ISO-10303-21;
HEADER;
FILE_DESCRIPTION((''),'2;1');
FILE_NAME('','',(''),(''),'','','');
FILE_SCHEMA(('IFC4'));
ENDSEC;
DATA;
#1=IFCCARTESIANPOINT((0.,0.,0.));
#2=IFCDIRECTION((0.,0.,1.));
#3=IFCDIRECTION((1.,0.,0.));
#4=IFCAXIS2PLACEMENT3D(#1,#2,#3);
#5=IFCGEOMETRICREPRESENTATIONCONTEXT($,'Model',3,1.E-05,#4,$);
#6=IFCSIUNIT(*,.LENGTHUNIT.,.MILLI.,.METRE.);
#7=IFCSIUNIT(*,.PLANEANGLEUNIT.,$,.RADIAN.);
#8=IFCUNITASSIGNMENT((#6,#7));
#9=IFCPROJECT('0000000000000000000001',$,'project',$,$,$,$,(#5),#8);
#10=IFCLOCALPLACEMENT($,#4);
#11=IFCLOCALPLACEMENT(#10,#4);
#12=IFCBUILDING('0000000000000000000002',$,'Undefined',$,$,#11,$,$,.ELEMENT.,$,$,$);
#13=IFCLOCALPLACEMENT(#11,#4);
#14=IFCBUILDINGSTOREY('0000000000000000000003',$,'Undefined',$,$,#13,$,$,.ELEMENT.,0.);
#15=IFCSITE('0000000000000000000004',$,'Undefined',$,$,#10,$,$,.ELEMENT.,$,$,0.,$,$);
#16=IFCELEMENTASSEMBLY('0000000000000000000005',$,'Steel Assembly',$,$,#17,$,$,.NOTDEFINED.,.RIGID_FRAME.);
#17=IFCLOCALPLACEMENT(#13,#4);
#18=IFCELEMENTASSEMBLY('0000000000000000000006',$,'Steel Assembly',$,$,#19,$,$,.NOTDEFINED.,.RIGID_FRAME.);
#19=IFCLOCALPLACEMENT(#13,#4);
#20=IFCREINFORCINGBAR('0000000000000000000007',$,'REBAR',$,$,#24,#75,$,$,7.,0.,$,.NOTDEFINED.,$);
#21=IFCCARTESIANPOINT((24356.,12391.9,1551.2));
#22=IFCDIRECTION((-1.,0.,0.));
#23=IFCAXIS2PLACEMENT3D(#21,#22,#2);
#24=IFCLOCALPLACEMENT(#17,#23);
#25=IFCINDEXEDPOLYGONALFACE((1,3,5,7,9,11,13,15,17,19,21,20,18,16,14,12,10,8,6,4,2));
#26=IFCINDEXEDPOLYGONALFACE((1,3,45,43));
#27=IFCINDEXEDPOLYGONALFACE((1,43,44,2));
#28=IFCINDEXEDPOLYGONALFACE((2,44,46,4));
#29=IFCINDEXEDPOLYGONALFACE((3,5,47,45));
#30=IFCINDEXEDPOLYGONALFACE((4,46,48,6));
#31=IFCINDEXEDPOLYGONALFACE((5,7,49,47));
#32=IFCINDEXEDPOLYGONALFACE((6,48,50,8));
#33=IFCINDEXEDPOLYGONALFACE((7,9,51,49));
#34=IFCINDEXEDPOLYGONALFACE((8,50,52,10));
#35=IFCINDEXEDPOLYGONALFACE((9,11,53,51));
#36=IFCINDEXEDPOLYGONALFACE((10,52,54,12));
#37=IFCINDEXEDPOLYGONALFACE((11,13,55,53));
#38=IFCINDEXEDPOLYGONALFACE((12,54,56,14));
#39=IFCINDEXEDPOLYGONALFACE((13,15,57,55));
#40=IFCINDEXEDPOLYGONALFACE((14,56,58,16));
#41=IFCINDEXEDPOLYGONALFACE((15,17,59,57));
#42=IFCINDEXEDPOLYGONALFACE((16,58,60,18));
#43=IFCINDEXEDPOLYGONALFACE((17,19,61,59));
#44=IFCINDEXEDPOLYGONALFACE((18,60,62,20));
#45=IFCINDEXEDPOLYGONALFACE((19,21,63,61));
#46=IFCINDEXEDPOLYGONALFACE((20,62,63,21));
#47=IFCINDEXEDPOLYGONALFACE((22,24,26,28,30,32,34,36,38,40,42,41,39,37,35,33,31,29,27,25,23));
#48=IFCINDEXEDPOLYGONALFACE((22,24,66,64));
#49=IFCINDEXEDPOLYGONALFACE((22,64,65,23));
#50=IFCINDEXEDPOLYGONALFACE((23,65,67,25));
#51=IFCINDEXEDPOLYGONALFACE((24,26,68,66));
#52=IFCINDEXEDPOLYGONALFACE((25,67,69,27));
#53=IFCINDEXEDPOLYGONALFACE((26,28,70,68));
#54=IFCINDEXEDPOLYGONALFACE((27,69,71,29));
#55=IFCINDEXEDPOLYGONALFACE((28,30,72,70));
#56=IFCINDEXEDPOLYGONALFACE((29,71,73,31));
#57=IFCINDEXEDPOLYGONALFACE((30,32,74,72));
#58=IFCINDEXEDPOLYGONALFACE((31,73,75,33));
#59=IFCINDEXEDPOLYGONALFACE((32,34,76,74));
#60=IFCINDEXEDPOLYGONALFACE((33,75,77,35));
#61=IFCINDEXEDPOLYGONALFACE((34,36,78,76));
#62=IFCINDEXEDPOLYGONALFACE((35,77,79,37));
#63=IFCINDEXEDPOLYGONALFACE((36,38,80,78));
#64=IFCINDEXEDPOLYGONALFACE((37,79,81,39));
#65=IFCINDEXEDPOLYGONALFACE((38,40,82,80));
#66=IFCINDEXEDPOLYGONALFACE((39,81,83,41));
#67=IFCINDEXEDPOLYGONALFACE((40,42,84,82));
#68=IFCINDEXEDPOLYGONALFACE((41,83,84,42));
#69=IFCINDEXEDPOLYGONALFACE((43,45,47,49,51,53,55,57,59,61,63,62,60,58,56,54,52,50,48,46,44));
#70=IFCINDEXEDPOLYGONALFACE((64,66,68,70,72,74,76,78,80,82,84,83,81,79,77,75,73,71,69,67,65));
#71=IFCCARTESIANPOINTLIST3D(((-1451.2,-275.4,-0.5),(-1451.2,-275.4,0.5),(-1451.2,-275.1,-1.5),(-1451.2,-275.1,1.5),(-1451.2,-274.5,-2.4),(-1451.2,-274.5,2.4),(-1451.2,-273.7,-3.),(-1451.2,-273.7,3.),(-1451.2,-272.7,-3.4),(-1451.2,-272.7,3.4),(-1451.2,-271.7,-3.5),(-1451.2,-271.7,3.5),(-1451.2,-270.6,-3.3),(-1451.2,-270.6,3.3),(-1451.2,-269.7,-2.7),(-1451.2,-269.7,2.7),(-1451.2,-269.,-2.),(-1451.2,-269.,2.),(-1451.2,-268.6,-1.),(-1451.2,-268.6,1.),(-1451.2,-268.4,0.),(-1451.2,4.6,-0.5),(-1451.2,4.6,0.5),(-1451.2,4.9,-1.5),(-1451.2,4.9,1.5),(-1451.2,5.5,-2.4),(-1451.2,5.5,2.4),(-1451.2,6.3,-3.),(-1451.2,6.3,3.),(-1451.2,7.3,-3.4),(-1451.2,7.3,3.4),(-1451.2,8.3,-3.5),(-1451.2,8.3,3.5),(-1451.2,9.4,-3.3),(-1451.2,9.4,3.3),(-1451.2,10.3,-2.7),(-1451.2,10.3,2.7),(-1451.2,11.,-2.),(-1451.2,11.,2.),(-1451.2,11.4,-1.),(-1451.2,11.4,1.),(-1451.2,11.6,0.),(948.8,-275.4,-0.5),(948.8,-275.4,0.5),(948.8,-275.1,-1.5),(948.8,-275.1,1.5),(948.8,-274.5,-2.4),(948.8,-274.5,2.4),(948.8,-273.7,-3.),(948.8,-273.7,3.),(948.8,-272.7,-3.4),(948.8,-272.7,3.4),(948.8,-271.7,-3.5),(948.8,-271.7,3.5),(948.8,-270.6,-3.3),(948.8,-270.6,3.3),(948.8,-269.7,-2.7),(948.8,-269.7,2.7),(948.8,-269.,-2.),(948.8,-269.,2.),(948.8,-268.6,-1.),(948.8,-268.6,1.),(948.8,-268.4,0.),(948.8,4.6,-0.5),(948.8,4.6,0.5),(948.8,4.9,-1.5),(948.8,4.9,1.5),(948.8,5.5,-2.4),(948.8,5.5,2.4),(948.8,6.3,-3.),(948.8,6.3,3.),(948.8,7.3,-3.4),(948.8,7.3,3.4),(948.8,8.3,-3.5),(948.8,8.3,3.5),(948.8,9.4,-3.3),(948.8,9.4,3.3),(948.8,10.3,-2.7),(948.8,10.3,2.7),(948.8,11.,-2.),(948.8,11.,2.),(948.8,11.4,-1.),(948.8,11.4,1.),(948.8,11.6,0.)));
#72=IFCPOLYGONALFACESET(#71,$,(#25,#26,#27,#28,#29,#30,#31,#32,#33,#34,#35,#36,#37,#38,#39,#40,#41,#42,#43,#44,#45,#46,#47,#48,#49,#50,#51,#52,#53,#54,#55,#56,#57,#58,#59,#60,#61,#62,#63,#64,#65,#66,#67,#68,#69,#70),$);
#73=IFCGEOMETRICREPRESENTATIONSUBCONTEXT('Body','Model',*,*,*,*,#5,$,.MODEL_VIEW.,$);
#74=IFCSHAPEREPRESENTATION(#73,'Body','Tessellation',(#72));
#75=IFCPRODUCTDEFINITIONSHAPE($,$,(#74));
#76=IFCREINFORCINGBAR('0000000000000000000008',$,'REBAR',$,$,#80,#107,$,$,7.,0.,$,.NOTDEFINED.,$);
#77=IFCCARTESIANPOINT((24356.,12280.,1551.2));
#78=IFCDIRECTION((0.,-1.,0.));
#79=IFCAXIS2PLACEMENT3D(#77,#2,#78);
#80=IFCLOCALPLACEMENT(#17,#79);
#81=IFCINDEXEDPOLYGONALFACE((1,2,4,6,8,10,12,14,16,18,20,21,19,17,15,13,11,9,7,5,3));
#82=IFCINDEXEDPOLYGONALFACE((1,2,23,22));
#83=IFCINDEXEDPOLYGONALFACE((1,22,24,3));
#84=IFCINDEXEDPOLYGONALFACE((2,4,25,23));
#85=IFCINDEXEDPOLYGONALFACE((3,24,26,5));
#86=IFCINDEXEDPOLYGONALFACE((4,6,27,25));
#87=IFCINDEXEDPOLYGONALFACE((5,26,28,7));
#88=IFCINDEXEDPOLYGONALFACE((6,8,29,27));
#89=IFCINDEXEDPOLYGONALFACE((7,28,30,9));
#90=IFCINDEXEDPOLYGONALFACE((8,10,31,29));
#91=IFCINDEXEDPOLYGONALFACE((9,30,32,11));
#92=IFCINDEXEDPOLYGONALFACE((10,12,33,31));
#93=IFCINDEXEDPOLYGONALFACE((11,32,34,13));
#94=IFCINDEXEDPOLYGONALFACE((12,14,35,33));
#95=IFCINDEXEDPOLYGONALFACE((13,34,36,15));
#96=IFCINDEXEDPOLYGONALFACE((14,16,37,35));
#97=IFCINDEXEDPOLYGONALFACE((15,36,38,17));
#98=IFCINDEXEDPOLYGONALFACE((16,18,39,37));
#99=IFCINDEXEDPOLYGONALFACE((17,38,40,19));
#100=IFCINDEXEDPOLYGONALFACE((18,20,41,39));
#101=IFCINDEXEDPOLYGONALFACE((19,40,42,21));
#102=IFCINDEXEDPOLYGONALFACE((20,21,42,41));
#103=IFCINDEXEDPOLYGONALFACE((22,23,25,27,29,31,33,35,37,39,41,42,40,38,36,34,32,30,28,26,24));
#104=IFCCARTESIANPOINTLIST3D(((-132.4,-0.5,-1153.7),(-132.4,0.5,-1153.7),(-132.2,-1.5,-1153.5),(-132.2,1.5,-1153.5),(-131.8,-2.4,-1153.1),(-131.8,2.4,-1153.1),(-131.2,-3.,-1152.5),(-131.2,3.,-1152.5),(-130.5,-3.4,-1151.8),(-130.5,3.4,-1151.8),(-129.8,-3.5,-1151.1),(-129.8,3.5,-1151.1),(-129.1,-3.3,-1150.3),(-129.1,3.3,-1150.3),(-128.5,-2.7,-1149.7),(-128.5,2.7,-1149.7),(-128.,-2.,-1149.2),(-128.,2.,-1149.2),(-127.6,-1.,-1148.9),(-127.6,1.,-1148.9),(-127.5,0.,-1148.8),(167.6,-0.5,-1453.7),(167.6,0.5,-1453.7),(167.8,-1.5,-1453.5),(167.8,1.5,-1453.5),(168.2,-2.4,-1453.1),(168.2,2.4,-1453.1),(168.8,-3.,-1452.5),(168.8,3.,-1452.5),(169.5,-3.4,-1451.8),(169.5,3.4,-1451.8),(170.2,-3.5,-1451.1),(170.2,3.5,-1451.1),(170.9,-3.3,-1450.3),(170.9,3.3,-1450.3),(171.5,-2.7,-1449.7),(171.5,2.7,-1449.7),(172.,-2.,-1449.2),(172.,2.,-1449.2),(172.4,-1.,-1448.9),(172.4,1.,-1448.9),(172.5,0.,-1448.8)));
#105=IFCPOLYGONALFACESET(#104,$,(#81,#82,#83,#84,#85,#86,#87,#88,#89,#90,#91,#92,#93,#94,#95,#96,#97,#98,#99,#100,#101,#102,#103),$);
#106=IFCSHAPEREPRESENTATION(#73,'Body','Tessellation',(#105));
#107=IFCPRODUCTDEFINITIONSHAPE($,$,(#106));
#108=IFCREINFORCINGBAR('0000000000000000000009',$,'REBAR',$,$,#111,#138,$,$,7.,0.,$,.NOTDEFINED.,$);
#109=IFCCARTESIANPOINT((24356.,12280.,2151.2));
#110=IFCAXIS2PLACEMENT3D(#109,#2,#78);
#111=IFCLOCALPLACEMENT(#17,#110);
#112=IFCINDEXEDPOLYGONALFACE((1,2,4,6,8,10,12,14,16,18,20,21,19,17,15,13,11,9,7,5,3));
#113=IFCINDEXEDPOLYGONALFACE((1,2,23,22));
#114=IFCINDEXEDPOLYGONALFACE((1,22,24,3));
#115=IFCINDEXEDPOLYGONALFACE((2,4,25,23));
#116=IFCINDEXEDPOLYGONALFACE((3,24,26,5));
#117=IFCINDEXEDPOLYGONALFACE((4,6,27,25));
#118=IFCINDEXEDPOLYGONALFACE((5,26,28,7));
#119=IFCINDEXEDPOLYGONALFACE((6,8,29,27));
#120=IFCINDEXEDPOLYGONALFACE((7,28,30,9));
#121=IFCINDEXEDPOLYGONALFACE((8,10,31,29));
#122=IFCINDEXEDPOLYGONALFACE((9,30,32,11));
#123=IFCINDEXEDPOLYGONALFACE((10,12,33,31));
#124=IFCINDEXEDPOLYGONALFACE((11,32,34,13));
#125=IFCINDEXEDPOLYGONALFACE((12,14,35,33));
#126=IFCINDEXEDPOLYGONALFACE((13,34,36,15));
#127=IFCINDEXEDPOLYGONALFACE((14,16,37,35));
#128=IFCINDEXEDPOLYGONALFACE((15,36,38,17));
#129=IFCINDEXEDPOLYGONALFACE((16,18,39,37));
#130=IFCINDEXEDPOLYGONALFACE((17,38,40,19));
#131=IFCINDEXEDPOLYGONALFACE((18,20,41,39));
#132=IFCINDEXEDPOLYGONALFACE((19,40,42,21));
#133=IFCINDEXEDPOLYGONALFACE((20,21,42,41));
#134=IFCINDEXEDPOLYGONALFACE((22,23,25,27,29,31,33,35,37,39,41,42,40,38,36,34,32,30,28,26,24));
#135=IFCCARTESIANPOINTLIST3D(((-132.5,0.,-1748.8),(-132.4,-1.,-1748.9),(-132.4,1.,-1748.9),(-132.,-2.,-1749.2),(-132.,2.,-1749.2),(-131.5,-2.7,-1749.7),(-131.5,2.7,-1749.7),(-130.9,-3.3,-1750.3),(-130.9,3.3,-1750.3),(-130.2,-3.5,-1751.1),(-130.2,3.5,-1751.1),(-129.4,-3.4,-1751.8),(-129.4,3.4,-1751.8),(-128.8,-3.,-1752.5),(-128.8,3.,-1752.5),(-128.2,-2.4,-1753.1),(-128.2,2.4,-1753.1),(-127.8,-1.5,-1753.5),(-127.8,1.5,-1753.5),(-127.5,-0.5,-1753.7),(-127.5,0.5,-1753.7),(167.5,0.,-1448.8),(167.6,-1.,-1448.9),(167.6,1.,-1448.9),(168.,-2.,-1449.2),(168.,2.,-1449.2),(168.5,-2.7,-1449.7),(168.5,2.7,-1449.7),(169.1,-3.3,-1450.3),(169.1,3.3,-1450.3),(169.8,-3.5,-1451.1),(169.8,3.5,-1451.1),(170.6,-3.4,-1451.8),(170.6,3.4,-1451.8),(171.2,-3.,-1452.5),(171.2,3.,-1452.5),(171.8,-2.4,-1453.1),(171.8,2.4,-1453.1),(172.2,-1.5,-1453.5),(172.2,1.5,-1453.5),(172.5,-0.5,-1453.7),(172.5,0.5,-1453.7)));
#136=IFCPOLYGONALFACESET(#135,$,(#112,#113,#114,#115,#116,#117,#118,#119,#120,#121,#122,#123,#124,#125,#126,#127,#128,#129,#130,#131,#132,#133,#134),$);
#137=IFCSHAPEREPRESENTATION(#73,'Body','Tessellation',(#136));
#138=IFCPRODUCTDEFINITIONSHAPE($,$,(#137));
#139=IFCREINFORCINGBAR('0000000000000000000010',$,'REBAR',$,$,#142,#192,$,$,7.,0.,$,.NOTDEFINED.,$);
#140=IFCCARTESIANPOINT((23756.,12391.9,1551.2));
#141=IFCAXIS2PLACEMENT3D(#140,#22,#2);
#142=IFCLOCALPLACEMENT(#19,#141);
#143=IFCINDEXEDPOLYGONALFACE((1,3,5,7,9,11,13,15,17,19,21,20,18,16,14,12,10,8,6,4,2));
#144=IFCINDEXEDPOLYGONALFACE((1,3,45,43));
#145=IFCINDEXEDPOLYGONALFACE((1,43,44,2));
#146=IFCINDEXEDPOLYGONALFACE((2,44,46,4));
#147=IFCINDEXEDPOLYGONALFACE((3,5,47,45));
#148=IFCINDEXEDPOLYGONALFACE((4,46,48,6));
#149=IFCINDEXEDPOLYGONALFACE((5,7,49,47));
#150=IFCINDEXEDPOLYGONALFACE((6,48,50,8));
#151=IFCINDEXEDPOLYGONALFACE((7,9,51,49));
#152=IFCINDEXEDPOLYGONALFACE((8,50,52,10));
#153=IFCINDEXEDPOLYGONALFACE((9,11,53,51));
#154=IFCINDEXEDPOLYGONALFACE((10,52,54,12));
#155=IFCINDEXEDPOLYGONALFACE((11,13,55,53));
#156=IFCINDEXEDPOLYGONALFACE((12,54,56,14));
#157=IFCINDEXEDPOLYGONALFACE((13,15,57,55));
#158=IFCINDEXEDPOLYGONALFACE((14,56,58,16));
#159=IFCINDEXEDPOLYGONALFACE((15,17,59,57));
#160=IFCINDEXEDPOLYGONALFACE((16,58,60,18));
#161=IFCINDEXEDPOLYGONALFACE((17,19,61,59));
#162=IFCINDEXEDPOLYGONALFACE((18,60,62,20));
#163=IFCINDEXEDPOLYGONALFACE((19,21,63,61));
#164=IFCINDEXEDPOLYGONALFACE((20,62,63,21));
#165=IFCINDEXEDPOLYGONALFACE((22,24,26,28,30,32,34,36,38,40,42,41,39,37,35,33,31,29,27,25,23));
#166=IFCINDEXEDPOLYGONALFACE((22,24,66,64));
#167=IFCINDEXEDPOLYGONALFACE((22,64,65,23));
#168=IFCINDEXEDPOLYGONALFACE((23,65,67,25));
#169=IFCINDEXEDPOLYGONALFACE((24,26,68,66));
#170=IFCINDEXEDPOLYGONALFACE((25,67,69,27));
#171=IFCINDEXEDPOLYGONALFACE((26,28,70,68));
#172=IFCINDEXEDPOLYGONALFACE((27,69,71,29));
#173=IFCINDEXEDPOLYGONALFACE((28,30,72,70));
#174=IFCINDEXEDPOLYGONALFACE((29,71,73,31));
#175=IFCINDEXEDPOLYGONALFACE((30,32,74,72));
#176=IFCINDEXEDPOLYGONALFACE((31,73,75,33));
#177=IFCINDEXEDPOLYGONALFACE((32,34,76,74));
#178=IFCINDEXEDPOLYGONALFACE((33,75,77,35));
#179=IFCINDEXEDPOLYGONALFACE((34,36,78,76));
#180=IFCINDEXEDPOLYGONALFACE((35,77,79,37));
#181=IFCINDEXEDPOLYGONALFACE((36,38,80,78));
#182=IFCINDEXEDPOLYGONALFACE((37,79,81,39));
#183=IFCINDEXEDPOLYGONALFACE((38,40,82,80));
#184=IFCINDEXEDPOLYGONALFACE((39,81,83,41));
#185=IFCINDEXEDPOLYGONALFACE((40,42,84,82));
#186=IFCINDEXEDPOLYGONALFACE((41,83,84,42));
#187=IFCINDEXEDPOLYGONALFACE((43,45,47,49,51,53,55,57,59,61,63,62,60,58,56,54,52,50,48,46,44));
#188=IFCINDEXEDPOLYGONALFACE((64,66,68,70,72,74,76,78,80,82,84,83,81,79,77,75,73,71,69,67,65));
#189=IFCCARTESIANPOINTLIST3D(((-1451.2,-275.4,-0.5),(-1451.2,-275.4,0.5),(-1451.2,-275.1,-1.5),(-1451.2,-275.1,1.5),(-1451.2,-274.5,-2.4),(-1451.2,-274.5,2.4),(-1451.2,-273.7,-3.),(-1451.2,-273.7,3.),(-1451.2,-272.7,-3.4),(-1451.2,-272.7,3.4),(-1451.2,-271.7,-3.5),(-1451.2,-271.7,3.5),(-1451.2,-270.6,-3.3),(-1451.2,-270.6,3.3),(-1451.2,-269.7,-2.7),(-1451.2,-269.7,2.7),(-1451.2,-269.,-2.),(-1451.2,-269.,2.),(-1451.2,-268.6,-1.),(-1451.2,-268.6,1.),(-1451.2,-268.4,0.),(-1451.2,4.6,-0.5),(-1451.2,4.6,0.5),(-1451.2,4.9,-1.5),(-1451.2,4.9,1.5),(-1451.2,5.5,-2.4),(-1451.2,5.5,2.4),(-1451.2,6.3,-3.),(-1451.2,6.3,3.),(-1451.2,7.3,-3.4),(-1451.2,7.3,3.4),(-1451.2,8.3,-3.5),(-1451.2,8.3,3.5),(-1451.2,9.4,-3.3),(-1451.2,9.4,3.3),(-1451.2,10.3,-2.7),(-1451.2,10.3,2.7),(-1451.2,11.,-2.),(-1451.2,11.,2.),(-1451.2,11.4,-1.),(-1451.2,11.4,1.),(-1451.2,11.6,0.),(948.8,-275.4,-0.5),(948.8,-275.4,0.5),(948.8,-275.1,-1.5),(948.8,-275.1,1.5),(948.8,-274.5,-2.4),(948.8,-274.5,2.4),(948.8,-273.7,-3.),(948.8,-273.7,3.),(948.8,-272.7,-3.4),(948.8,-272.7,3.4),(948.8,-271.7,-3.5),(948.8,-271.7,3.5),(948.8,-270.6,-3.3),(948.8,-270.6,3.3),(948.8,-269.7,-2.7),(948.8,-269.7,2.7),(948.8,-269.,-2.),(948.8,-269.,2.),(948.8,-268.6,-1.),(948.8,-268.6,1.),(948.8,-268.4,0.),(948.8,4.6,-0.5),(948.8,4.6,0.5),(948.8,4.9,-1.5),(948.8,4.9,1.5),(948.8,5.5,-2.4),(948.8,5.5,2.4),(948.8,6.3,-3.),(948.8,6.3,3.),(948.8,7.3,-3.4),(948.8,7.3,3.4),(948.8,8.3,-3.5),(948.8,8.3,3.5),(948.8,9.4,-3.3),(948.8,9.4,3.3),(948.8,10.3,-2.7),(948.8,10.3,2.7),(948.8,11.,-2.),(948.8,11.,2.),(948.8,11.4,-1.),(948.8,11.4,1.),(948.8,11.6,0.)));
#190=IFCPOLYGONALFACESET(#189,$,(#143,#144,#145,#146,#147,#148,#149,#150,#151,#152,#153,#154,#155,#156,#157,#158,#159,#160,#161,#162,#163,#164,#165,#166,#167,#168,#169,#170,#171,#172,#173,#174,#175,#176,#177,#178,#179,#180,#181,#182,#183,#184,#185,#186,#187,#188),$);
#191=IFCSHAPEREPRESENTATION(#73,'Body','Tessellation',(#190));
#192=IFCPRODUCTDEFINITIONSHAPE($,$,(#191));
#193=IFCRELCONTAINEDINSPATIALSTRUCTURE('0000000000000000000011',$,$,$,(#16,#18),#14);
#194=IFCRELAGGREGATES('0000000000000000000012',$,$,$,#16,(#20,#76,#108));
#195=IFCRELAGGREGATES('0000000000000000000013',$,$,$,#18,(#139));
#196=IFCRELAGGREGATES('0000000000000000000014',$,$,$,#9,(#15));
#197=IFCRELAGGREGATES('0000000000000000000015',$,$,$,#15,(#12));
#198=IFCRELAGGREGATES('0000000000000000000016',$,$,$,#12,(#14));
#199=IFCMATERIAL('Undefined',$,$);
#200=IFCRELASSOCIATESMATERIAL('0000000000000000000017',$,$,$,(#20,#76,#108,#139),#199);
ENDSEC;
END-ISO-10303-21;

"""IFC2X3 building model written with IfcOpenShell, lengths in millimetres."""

from ifc_helpers import new_model, entity, si_unit, frame, origin_with_axes, place, context, subcontext, project, spatial, source, transform, mapped, material, element, aggregate, save


model = new_model("IFC2X3")

# Units and contexts
model_context = context("Model", 3, precision=1e-05, world=origin_with_axes())
body_context = subcontext(model_context, "Body", "Model", "MODEL_VIEW")
ifc_project = project(units=[si_unit("LENGTHUNIT", "METRE", prefix="MILLI"), si_unit("PLANEANGLEUNIT", "RADIAN")], contexts=[model_context])

# Site, building, storey
site_placement = place(None, origin_with_axes())
site = spatial("IfcSite", under=ifc_project, at=site_placement, Name="Undefined", CompositionType="ELEMENT", RefElevation=0.0)
building_placement = place(site_placement, origin_with_axes())
building = spatial("IfcBuilding", under=site, at=building_placement, Name="Undefined", CompositionType="ELEMENT")
storey_placement = place(building_placement, origin_with_axes())
storey = spatial("IfcBuildingStorey", under=building, at=storey_placement, Name="Undefined", CompositionType="ELEMENT", Elevation=0.0)

# Element assemblies
assembly_1_placement = place(storey_placement, origin_with_axes())
assembly_1 = element("IfcElementAssembly", 1, at=assembly_1_placement, inside=storey, Name="Steel Assembly", AssemblyPlace="NOTDEFINED", PredefinedType="RIGID_FRAME")
assembly_2_placement = place(storey_placement, origin_with_axes())
assembly_2 = element("IfcElementAssembly", 2, at=assembly_2_placement, inside=storey, Name="Steel Assembly", AssemblyPlace="NOTDEFINED", PredefinedType="RIGID_FRAME")

# Shared definitions
ifc_material_1 = material(Name="Undefined")

# Reinforcing bars
shared_shape_1 = source(origin_with_axes(), body_context, "Body", "AdvancedSweptSolid", [
    entity("IfcSweptDiskSolid", entity("IfcTrimmedCurve", entity("IfcLine", entity("IfcCartesianPoint", [0.0, 0.0, 0.0]), entity("IfcVector", entity("IfcDirection", [1.0, 0.000003, 0.0]), 1.0)), [entity("IfcParameterValue", 0.0)], [entity("IfcParameterValue", 2400.0)], True, "PARAMETER"), 3.5, None, 0.0, 2400.0),
])
shared_shape_2 = source(origin_with_axes(), body_context, "Body", "AdvancedSweptSolid", [
    entity("IfcSweptDiskSolid", entity("IfcTrimmedCurve", entity("IfcLine", entity("IfcCartesianPoint", [0.0, 0.0, 0.0]), entity("IfcVector", entity("IfcDirection", [1.0, 0.000003, 0.0]), 1.0)), [entity("IfcParameterValue", 0.0)], [entity("IfcParameterValue", 2400.0)], True, "PARAMETER"), 3.5, None, 0.0, 2400.0),
])
reinforcing_bar_1_placement = place(assembly_1_placement, frame((24356.0, 12391.9, 1551.2), z_axis=(-1.0, 0.0, 0.0), x_axis=(0.0, 0.0, 1.0)))
reinforcing_bar_1 = element("IfcReinforcingBar", 3, at=reinforcing_bar_1_placement, material=ifc_material_1, Name="REBAR", BarRole="NOTDEFINED", CrossSectionArea=0.0, NominalDiameter=7.0, context=body_context, shape_type="MappedRepresentation", body=[
    mapped(shared_shape_1, transform((-1451.2, -271.9, 0.0))),
    mapped(shared_shape_2, transform((-1451.2, 8.1, 0.0))),
])
shared_shape_3 = source(origin_with_axes(), body_context, "Body", "AdvancedSweptSolid", [
    entity("IfcSweptDiskSolid", entity("IfcTrimmedCurve", entity("IfcLine", entity("IfcCartesianPoint", [0.0, 0.0, 0.0]), entity("IfcVector", entity("IfcDirection", [0.707107, 0.0, -0.707107]), 1.0)), [entity("IfcParameterValue", 0.0)], [entity("IfcParameterValue", 424.264069)], True, "PARAMETER"), 3.5, None, 0.0, 424.3),
])
reinforcing_bar_2_placement = place(assembly_1_placement, frame((24356.0, 12280.0, 1551.2), z_axis=(0.0, 0.0, 1.0), x_axis=(0.0, -1.0, 0.0)))
reinforcing_bar_2 = element("IfcReinforcingBar", 4, at=reinforcing_bar_2_placement, material=ifc_material_1, Name="REBAR", BarRole="NOTDEFINED", CrossSectionArea=0.0, NominalDiameter=7.0, context=body_context, shape_type="MappedRepresentation", body=[
    mapped(shared_shape_3, transform((-130.0, 0.0, -1151.2))),
])
shared_shape_4 = source(origin_with_axes(), body_context, "Body", "AdvancedSweptSolid", [
    entity("IfcSweptDiskSolid", entity("IfcTrimmedCurve", entity("IfcLine", entity("IfcCartesianPoint", [0.0, 0.0, 0.0]), entity("IfcVector", entity("IfcDirection", [0.707107, 0.0, 0.707107]), 1.0)), [entity("IfcParameterValue", 0.0)], [entity("IfcParameterValue", 424.264069)], True, "PARAMETER"), 3.5, None, 0.0, 424.3),
])
reinforcing_bar_3_placement = place(assembly_1_placement, frame((24356.0, 12280.0, 2151.2), z_axis=(0.0, 0.0, 1.0), x_axis=(0.0, -1.0, 0.0)))
reinforcing_bar_3 = element("IfcReinforcingBar", 5, at=reinforcing_bar_3_placement, material=ifc_material_1, Name="REBAR", BarRole="NOTDEFINED", CrossSectionArea=0.0, NominalDiameter=7.0, context=body_context, shape_type="MappedRepresentation", body=[
    mapped(shared_shape_4, transform((-130.0, 0.0, -1751.2))),
])
aggregate(assembly_1, [reinforcing_bar_1, reinforcing_bar_2, reinforcing_bar_3])
shared_shape_5 = source(origin_with_axes(), body_context, "Body", "AdvancedSweptSolid", [
    entity("IfcSweptDiskSolid", entity("IfcTrimmedCurve", entity("IfcLine", entity("IfcCartesianPoint", [0.0, 0.0, 0.0]), entity("IfcVector", entity("IfcDirection", [1.0, 0.000003, 0.0]), 1.0)), [entity("IfcParameterValue", 0.0)], [entity("IfcParameterValue", 2400.0)], True, "PARAMETER"), 3.5, None, 0.0, 2400.0),
])
shared_shape_6 = source(origin_with_axes(), body_context, "Body", "AdvancedSweptSolid", [
    entity("IfcSweptDiskSolid", entity("IfcTrimmedCurve", entity("IfcLine", entity("IfcCartesianPoint", [0.0, 0.0, 0.0]), entity("IfcVector", entity("IfcDirection", [1.0, 0.000003, 0.0]), 1.0)), [entity("IfcParameterValue", 0.0)], [entity("IfcParameterValue", 2400.0)], True, "PARAMETER"), 3.5, None, 0.0, 2400.0),
])
reinforcing_bar_4_placement = place(assembly_2_placement, frame((23756.0, 12391.9, 1551.2), z_axis=(-1.0, 0.0, 0.0), x_axis=(0.0, 0.0, 1.0)))
reinforcing_bar_4 = element("IfcReinforcingBar", 6, at=reinforcing_bar_4_placement, material=ifc_material_1, Name="REBAR", BarRole="NOTDEFINED", CrossSectionArea=0.0, NominalDiameter=7.0, context=body_context, shape_type="MappedRepresentation", body=[
    mapped(shared_shape_5, transform((-1451.2, -271.9, 0.0))),
    mapped(shared_shape_6, transform((-1451.2, 8.1, 0.0))),
])
aggregate(assembly_2, [reinforcing_bar_4])

save(model, "model.ifc")
